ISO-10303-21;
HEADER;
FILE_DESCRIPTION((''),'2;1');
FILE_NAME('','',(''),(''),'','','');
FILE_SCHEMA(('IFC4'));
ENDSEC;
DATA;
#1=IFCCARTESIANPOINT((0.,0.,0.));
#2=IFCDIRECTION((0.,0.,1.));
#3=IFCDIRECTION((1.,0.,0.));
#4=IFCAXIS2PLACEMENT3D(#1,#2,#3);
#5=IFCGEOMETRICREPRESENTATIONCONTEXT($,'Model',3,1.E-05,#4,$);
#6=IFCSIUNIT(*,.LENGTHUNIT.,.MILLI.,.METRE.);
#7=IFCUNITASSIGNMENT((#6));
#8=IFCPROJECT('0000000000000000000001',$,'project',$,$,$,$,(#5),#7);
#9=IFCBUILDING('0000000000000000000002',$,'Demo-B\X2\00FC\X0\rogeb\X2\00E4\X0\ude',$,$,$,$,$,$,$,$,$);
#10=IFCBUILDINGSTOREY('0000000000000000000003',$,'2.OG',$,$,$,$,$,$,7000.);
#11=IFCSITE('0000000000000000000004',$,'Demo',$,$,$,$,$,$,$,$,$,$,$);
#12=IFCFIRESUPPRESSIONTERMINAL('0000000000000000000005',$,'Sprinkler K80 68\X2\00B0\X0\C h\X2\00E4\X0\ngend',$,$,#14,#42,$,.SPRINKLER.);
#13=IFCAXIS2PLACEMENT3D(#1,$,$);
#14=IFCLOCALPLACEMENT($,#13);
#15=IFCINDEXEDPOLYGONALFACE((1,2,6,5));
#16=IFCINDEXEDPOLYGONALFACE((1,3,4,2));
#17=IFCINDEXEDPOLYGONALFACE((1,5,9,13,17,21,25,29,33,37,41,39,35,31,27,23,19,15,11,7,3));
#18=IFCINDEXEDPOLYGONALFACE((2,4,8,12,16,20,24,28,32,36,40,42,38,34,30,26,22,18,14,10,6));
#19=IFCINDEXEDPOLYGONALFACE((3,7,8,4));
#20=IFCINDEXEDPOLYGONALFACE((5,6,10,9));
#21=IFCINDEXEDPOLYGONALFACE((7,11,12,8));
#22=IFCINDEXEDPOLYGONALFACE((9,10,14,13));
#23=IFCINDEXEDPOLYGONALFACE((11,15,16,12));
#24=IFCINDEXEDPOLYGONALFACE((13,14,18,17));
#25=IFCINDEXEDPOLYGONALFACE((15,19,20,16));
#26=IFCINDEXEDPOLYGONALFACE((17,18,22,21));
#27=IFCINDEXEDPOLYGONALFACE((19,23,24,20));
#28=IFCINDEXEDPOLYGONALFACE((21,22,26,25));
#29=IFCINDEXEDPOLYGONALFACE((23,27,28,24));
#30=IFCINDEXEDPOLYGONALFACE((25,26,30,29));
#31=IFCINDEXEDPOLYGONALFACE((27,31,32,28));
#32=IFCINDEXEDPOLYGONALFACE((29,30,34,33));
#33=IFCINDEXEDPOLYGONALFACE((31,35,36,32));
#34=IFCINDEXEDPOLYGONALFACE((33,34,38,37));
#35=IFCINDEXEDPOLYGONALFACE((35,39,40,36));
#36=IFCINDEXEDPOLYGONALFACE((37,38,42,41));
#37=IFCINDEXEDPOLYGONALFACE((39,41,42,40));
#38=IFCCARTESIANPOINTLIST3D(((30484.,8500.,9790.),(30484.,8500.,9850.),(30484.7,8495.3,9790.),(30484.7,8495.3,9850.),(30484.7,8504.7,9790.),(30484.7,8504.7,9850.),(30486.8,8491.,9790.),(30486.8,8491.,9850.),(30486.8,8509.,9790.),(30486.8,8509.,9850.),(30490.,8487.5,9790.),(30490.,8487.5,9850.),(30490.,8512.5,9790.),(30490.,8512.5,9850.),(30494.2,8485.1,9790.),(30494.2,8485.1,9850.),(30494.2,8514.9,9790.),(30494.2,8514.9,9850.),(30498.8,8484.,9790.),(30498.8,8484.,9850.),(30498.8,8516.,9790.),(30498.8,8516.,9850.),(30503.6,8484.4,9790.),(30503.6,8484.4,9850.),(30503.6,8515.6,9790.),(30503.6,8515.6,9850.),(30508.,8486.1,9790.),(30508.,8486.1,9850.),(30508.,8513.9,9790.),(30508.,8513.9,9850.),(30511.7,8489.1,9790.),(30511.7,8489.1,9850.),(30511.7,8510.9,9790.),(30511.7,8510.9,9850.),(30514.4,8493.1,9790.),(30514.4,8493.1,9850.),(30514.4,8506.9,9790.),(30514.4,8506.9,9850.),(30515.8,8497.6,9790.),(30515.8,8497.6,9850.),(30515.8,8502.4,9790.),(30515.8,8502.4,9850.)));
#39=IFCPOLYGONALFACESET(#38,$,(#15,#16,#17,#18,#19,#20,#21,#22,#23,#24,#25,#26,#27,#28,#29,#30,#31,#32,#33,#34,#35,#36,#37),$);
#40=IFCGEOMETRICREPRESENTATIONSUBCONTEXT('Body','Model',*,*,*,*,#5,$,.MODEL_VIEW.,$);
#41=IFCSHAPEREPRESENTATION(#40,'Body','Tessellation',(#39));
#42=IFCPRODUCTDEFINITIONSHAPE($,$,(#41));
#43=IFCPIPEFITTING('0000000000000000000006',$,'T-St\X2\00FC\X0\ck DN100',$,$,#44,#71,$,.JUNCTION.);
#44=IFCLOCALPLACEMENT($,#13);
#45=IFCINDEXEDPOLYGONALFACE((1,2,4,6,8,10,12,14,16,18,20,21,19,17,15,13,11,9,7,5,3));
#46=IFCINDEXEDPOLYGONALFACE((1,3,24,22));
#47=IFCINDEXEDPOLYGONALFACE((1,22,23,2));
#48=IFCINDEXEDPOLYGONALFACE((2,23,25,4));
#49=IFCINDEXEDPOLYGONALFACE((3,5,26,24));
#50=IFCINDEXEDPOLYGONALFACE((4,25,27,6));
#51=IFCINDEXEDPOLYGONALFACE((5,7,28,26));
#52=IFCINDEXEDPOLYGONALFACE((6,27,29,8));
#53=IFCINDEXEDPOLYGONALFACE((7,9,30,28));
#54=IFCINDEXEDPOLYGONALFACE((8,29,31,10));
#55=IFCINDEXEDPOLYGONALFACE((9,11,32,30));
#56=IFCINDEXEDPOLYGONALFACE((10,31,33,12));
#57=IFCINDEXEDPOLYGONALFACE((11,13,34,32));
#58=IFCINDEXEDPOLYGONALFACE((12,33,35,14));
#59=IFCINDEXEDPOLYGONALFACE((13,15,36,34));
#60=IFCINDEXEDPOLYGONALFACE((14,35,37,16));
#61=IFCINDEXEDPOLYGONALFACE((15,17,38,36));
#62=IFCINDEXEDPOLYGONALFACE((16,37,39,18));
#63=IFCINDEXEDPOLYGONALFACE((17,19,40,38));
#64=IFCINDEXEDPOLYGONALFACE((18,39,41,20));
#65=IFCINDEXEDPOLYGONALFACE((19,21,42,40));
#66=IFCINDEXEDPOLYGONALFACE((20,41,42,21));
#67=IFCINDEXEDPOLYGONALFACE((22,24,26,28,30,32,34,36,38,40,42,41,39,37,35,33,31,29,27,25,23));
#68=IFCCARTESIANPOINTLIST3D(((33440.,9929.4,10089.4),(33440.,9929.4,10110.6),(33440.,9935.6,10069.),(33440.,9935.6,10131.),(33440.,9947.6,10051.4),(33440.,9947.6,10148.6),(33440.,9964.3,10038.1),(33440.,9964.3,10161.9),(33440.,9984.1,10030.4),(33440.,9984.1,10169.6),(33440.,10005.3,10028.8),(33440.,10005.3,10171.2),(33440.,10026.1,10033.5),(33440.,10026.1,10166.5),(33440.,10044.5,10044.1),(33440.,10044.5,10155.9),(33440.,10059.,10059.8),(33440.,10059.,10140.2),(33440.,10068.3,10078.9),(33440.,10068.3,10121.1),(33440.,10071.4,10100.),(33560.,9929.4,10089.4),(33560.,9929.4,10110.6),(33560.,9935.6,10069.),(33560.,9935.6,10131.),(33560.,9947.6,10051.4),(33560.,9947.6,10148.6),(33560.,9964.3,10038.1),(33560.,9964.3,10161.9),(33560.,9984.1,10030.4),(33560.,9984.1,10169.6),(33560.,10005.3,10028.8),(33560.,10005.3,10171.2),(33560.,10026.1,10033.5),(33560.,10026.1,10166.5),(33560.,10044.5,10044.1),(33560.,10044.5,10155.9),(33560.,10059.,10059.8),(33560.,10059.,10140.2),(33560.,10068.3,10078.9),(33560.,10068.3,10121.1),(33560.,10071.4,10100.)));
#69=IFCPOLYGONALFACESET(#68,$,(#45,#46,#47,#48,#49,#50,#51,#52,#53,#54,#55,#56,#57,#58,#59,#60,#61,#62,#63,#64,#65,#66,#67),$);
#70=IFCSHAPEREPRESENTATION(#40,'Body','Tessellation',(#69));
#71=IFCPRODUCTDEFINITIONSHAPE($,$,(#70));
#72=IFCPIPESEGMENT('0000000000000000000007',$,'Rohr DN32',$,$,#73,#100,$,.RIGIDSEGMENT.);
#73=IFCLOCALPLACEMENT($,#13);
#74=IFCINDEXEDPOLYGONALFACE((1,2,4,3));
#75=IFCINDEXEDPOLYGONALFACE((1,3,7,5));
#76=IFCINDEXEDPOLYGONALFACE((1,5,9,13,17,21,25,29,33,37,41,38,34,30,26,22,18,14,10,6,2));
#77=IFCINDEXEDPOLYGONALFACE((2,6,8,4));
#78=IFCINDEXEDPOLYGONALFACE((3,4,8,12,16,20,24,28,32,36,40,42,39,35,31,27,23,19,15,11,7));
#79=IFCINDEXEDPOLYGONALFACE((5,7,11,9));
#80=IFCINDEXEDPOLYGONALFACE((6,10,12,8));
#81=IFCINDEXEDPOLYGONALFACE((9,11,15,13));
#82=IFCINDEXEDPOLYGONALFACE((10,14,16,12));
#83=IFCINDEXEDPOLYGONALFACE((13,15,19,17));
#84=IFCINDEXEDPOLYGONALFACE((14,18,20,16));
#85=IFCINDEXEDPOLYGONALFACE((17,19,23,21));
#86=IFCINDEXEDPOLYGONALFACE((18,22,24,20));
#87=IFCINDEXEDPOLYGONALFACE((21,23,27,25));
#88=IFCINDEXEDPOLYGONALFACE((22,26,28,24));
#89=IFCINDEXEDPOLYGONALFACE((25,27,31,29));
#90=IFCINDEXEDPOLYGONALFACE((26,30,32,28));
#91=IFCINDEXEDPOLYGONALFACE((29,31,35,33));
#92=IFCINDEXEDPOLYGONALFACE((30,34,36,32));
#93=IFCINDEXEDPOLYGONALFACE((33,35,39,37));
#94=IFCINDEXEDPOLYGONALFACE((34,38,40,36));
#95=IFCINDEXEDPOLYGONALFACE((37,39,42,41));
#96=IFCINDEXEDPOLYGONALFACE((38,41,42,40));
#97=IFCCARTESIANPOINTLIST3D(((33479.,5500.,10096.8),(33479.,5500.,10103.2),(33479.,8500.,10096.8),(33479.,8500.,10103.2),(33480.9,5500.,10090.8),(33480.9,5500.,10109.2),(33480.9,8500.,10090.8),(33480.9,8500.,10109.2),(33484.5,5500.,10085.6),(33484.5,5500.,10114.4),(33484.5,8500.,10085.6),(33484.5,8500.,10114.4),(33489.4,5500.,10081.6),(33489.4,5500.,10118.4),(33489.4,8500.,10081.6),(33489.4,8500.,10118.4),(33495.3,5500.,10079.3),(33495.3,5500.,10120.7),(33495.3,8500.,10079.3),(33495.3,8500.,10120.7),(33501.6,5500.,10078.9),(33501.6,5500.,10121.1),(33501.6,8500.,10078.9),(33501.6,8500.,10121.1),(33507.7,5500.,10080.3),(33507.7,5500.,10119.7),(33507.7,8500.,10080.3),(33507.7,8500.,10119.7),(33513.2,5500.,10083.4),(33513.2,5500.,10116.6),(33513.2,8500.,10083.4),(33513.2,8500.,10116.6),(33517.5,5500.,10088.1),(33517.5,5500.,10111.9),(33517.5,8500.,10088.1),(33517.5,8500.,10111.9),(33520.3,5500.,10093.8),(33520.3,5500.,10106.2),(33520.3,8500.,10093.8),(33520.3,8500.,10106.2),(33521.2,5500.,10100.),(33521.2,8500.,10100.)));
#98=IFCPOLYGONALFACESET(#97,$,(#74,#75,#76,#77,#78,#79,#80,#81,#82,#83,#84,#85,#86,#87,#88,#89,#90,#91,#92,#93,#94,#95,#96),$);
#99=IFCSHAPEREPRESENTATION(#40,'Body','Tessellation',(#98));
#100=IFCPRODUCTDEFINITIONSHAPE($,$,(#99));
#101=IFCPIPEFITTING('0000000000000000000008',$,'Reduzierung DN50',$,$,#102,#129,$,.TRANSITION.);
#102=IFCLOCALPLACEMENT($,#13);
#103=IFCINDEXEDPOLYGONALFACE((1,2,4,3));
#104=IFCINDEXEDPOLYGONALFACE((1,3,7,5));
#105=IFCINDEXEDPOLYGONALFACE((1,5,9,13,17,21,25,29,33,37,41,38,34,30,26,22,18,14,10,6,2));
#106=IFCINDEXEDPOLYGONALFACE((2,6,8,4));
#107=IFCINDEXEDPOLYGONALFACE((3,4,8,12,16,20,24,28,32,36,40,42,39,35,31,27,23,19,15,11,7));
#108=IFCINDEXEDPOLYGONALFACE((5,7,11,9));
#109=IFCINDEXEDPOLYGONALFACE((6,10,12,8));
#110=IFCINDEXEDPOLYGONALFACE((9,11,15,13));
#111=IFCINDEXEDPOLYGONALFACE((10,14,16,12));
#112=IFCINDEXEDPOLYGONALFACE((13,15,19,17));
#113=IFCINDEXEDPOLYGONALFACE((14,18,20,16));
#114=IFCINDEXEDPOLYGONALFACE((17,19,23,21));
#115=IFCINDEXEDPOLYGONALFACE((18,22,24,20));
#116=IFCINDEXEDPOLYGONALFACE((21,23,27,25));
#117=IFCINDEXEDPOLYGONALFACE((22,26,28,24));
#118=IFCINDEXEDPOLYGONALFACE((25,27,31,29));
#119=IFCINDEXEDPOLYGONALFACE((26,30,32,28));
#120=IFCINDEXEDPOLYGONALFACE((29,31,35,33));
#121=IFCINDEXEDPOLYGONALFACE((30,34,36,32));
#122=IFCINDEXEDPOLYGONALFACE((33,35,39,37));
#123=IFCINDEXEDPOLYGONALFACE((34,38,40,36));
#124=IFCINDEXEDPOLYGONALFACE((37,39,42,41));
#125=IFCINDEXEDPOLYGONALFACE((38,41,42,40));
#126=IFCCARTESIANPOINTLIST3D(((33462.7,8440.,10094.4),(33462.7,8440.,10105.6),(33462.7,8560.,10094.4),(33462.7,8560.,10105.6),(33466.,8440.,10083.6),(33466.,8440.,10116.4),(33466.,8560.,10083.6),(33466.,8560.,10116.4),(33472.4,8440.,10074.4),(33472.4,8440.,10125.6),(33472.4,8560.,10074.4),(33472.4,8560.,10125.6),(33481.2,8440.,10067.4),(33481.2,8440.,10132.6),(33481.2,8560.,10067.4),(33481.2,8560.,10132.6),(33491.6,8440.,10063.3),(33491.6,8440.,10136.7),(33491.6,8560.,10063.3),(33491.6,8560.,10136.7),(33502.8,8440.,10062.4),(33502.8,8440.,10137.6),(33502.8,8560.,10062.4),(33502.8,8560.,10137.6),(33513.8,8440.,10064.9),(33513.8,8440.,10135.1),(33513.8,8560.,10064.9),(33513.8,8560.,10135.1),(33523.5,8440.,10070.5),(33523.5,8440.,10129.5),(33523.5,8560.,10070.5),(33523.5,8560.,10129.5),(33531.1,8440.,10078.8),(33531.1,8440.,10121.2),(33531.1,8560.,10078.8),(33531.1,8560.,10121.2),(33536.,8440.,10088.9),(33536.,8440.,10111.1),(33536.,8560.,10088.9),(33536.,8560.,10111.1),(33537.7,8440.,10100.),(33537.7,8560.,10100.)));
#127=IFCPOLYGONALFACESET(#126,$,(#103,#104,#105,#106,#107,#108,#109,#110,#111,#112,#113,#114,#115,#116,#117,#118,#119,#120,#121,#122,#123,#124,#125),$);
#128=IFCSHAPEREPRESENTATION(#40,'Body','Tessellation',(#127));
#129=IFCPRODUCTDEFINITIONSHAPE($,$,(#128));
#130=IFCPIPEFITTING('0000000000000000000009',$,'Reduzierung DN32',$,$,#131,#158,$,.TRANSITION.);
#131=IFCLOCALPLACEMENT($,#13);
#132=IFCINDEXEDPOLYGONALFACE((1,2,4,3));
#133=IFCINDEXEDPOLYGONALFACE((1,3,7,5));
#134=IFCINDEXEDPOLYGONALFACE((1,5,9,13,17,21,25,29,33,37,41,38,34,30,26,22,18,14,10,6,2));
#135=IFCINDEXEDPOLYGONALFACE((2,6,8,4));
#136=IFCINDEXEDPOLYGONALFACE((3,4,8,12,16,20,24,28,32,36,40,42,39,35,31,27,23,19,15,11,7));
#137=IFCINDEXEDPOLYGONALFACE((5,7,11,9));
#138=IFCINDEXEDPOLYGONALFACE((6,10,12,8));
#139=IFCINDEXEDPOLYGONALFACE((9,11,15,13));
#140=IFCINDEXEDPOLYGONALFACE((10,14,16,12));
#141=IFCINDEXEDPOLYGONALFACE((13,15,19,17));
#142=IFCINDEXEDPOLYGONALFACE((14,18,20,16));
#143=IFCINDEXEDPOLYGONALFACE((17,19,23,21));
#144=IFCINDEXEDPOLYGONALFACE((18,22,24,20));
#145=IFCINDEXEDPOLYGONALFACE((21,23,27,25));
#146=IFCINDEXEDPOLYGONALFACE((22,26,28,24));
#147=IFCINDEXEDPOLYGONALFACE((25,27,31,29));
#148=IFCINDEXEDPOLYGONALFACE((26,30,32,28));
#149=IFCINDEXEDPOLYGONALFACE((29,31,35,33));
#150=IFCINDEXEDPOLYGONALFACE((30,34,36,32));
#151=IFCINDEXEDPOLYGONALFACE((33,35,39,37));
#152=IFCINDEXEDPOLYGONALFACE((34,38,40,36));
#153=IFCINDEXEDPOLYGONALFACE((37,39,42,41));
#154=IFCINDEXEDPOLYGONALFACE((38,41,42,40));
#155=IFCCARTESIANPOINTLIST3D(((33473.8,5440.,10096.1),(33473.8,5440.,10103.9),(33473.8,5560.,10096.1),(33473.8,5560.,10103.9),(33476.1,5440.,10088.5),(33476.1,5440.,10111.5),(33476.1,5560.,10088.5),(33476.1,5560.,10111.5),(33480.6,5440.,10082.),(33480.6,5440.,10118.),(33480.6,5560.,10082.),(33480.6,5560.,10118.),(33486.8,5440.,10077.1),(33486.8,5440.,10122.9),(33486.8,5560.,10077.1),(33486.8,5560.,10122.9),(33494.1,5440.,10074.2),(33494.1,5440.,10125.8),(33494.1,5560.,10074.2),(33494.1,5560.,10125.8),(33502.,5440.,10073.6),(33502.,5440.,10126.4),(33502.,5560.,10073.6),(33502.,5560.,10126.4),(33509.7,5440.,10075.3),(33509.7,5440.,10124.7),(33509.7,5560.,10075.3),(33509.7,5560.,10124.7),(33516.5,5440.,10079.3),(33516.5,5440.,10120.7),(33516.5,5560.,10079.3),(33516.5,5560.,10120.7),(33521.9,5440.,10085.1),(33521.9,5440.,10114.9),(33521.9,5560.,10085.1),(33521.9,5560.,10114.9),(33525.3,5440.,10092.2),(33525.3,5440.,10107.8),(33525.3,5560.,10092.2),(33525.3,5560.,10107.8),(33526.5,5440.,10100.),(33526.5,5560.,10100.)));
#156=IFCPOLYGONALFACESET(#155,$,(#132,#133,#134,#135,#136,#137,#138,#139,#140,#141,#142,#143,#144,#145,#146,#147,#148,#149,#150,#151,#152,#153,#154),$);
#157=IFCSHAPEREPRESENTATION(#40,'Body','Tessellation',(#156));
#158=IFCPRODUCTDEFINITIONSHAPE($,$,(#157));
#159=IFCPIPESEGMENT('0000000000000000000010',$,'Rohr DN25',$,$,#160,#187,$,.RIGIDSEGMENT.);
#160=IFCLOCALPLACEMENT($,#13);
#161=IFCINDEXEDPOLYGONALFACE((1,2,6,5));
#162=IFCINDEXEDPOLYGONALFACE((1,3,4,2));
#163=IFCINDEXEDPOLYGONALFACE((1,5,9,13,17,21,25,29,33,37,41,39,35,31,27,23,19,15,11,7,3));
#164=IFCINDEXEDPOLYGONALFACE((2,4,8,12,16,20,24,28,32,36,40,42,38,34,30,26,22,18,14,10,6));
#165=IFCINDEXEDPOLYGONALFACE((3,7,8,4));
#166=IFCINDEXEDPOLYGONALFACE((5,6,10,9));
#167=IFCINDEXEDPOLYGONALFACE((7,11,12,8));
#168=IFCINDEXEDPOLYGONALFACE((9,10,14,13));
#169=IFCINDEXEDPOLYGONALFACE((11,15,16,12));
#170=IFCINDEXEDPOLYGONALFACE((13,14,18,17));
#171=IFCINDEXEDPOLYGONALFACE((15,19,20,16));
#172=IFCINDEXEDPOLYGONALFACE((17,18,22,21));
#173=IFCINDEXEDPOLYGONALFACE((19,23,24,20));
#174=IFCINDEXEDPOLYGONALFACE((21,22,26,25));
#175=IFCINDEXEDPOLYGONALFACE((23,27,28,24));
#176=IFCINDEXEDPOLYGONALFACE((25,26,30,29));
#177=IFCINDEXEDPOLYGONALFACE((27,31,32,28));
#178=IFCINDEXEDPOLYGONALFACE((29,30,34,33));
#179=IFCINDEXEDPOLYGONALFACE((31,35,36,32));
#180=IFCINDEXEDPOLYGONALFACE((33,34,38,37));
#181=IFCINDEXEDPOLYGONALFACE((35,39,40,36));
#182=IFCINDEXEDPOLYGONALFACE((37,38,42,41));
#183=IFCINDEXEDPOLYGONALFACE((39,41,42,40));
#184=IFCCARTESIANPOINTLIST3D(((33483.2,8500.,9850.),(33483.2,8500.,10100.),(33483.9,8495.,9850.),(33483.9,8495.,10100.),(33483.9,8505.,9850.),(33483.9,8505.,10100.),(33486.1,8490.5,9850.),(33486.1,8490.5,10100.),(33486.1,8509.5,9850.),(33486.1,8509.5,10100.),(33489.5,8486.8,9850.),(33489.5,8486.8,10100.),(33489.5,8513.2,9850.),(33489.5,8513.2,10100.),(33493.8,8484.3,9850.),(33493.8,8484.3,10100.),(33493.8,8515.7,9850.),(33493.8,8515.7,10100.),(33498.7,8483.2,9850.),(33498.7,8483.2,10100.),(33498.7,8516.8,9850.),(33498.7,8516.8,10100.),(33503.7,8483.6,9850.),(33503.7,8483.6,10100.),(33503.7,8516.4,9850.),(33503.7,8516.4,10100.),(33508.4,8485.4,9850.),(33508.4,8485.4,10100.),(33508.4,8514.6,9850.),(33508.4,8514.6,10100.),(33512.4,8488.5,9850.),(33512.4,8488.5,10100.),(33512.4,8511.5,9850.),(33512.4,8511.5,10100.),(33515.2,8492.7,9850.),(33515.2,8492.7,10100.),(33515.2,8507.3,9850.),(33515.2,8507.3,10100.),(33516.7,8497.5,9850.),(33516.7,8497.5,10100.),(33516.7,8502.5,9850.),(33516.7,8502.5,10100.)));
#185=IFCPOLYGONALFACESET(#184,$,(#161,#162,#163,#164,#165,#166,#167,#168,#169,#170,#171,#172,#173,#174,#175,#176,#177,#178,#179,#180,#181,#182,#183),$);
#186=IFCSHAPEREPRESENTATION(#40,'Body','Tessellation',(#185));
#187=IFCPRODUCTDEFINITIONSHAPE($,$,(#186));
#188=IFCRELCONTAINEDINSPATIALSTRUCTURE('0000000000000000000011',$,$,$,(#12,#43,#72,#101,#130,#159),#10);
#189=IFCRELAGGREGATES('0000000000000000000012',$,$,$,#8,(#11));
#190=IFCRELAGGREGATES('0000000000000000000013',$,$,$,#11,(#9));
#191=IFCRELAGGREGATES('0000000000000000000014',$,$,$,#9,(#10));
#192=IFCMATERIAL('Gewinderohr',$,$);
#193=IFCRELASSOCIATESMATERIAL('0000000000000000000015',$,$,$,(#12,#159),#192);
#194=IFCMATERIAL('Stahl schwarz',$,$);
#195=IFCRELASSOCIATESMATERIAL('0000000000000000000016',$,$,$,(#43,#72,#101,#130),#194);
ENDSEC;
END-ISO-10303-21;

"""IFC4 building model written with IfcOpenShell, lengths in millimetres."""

from ifc_helpers import new_model, si_unit, frame, origin_with_axes, place, context, subcontext, project, spatial, circle, extrude, material, element, save


model = new_model("IFC4")

# Units and contexts
model_context = context("Model", 3, precision=1e-05, world=origin_with_axes())
body_context = subcontext(model_context, "Body", "Model", "MODEL_VIEW")
ifc_project = project(units=[si_unit("LENGTHUNIT", "METRE", prefix="MILLI")], contexts=[model_context])

# Site, building, storey
site = spatial("IfcSite", under=ifc_project, Name="Demo")
building = spatial("IfcBuilding", under=site, Name="Demo-Bürogebäude")
storey = spatial("IfcBuildingStorey", under=building, Name="2.OG", Elevation=7000.0)

# Shared definitions
ifc_material_1 = material(Name="Stahl schwarz")

# Shared definitions
ifc_material_2 = material(Name="Gewinderohr")

# Fire suppression terminal
fire_suppression_terminal_1_placement = place(None, frame((30500.0, 8500.0, 9850.0), z_axis=(0.0, 0.0, -1.0), x_axis=(-1.0, 0.0, 0.0)))
element("IfcFireSuppressionTerminal", 1, at=fire_suppression_terminal_1_placement, inside=storey, material=ifc_material_2, Name="Sprinkler K80 68°C hängend", PredefinedType="SPRINKLER", context=body_context, shape_type="SweptSolid", body=[
    extrude(circle(Radius=16.0), origin_with_axes(), (0.0, 0.0, 1.0), 60.0),
])

# Pipe fitting
pipe_fitting_1_placement = place(None, frame((33440.0, 10000.0, 10100.0), z_axis=(1.0, 0.0, 0.0), x_axis=(0.0, 1.0, 0.0)))
element("IfcPipeFitting", 2, at=pipe_fitting_1_placement, inside=storey, material=ifc_material_1, Name="T-Stück DN100", PredefinedType="JUNCTION", context=body_context, shape_type="SweptSolid", body=[
    extrude(circle(Radius=71.4), origin_with_axes(), (0.0, 0.0, 1.0), 120.0),
])

# Pipe segment
pipe_segment_1_placement = place(None, frame((33500.0, 8500.0, 10100.0), z_axis=(0.0, -1.0, 0.0), x_axis=(1.0, 0.0, 0.0)))
element("IfcPipeSegment", 3, at=pipe_segment_1_placement, inside=storey, material=ifc_material_1, Name="Rohr DN32", PredefinedType="RIGIDSEGMENT", context=body_context, shape_type="SweptSolid", body=[
    extrude(circle(Radius=21.2), origin_with_axes(), (0.0, 0.0, 1.0), 3000.0),
])

# Pipe fittings
pipe_fitting_2_placement = place(None, frame((33500.0, 8560.0, 10100.0), z_axis=(0.0, -1.0, 0.0), x_axis=(1.0, 0.0, 0.0)))
element("IfcPipeFitting", 4, at=pipe_fitting_2_placement, inside=storey, material=ifc_material_1, Name="Reduzierung DN50", PredefinedType="TRANSITION", context=body_context, shape_type="SweptSolid", body=[
    extrude(circle(Radius=37.7), origin_with_axes(), (0.0, 0.0, 1.0), 120.0),
])
pipe_fitting_3_placement = place(None, frame((33500.0, 5560.0, 10100.0), z_axis=(0.0, -1.0, 0.0), x_axis=(1.0, 0.0, 0.0)))
element("IfcPipeFitting", 5, at=pipe_fitting_3_placement, inside=storey, material=ifc_material_1, Name="Reduzierung DN32", PredefinedType="TRANSITION", context=body_context, shape_type="SweptSolid", body=[
    extrude(circle(Radius=26.5), origin_with_axes(), (0.0, 0.0, 1.0), 120.0),
])

# Pipe segment
pipe_segment_2_placement = place(None, frame((33500.0, 8500.0, 10100.0), z_axis=(0.0, 0.0, -1.0), x_axis=(-1.0, 0.0, 0.0)))
element("IfcPipeSegment", 6, at=pipe_segment_2_placement, inside=storey, material=ifc_material_2, Name="Rohr DN25", PredefinedType="RIGIDSEGMENT", context=body_context, shape_type="SweptSolid", body=[
    extrude(circle(Radius=16.9), origin_with_axes(), (0.0, 0.0, 1.0), 250.0),
])

save(model, "model.ifc")
